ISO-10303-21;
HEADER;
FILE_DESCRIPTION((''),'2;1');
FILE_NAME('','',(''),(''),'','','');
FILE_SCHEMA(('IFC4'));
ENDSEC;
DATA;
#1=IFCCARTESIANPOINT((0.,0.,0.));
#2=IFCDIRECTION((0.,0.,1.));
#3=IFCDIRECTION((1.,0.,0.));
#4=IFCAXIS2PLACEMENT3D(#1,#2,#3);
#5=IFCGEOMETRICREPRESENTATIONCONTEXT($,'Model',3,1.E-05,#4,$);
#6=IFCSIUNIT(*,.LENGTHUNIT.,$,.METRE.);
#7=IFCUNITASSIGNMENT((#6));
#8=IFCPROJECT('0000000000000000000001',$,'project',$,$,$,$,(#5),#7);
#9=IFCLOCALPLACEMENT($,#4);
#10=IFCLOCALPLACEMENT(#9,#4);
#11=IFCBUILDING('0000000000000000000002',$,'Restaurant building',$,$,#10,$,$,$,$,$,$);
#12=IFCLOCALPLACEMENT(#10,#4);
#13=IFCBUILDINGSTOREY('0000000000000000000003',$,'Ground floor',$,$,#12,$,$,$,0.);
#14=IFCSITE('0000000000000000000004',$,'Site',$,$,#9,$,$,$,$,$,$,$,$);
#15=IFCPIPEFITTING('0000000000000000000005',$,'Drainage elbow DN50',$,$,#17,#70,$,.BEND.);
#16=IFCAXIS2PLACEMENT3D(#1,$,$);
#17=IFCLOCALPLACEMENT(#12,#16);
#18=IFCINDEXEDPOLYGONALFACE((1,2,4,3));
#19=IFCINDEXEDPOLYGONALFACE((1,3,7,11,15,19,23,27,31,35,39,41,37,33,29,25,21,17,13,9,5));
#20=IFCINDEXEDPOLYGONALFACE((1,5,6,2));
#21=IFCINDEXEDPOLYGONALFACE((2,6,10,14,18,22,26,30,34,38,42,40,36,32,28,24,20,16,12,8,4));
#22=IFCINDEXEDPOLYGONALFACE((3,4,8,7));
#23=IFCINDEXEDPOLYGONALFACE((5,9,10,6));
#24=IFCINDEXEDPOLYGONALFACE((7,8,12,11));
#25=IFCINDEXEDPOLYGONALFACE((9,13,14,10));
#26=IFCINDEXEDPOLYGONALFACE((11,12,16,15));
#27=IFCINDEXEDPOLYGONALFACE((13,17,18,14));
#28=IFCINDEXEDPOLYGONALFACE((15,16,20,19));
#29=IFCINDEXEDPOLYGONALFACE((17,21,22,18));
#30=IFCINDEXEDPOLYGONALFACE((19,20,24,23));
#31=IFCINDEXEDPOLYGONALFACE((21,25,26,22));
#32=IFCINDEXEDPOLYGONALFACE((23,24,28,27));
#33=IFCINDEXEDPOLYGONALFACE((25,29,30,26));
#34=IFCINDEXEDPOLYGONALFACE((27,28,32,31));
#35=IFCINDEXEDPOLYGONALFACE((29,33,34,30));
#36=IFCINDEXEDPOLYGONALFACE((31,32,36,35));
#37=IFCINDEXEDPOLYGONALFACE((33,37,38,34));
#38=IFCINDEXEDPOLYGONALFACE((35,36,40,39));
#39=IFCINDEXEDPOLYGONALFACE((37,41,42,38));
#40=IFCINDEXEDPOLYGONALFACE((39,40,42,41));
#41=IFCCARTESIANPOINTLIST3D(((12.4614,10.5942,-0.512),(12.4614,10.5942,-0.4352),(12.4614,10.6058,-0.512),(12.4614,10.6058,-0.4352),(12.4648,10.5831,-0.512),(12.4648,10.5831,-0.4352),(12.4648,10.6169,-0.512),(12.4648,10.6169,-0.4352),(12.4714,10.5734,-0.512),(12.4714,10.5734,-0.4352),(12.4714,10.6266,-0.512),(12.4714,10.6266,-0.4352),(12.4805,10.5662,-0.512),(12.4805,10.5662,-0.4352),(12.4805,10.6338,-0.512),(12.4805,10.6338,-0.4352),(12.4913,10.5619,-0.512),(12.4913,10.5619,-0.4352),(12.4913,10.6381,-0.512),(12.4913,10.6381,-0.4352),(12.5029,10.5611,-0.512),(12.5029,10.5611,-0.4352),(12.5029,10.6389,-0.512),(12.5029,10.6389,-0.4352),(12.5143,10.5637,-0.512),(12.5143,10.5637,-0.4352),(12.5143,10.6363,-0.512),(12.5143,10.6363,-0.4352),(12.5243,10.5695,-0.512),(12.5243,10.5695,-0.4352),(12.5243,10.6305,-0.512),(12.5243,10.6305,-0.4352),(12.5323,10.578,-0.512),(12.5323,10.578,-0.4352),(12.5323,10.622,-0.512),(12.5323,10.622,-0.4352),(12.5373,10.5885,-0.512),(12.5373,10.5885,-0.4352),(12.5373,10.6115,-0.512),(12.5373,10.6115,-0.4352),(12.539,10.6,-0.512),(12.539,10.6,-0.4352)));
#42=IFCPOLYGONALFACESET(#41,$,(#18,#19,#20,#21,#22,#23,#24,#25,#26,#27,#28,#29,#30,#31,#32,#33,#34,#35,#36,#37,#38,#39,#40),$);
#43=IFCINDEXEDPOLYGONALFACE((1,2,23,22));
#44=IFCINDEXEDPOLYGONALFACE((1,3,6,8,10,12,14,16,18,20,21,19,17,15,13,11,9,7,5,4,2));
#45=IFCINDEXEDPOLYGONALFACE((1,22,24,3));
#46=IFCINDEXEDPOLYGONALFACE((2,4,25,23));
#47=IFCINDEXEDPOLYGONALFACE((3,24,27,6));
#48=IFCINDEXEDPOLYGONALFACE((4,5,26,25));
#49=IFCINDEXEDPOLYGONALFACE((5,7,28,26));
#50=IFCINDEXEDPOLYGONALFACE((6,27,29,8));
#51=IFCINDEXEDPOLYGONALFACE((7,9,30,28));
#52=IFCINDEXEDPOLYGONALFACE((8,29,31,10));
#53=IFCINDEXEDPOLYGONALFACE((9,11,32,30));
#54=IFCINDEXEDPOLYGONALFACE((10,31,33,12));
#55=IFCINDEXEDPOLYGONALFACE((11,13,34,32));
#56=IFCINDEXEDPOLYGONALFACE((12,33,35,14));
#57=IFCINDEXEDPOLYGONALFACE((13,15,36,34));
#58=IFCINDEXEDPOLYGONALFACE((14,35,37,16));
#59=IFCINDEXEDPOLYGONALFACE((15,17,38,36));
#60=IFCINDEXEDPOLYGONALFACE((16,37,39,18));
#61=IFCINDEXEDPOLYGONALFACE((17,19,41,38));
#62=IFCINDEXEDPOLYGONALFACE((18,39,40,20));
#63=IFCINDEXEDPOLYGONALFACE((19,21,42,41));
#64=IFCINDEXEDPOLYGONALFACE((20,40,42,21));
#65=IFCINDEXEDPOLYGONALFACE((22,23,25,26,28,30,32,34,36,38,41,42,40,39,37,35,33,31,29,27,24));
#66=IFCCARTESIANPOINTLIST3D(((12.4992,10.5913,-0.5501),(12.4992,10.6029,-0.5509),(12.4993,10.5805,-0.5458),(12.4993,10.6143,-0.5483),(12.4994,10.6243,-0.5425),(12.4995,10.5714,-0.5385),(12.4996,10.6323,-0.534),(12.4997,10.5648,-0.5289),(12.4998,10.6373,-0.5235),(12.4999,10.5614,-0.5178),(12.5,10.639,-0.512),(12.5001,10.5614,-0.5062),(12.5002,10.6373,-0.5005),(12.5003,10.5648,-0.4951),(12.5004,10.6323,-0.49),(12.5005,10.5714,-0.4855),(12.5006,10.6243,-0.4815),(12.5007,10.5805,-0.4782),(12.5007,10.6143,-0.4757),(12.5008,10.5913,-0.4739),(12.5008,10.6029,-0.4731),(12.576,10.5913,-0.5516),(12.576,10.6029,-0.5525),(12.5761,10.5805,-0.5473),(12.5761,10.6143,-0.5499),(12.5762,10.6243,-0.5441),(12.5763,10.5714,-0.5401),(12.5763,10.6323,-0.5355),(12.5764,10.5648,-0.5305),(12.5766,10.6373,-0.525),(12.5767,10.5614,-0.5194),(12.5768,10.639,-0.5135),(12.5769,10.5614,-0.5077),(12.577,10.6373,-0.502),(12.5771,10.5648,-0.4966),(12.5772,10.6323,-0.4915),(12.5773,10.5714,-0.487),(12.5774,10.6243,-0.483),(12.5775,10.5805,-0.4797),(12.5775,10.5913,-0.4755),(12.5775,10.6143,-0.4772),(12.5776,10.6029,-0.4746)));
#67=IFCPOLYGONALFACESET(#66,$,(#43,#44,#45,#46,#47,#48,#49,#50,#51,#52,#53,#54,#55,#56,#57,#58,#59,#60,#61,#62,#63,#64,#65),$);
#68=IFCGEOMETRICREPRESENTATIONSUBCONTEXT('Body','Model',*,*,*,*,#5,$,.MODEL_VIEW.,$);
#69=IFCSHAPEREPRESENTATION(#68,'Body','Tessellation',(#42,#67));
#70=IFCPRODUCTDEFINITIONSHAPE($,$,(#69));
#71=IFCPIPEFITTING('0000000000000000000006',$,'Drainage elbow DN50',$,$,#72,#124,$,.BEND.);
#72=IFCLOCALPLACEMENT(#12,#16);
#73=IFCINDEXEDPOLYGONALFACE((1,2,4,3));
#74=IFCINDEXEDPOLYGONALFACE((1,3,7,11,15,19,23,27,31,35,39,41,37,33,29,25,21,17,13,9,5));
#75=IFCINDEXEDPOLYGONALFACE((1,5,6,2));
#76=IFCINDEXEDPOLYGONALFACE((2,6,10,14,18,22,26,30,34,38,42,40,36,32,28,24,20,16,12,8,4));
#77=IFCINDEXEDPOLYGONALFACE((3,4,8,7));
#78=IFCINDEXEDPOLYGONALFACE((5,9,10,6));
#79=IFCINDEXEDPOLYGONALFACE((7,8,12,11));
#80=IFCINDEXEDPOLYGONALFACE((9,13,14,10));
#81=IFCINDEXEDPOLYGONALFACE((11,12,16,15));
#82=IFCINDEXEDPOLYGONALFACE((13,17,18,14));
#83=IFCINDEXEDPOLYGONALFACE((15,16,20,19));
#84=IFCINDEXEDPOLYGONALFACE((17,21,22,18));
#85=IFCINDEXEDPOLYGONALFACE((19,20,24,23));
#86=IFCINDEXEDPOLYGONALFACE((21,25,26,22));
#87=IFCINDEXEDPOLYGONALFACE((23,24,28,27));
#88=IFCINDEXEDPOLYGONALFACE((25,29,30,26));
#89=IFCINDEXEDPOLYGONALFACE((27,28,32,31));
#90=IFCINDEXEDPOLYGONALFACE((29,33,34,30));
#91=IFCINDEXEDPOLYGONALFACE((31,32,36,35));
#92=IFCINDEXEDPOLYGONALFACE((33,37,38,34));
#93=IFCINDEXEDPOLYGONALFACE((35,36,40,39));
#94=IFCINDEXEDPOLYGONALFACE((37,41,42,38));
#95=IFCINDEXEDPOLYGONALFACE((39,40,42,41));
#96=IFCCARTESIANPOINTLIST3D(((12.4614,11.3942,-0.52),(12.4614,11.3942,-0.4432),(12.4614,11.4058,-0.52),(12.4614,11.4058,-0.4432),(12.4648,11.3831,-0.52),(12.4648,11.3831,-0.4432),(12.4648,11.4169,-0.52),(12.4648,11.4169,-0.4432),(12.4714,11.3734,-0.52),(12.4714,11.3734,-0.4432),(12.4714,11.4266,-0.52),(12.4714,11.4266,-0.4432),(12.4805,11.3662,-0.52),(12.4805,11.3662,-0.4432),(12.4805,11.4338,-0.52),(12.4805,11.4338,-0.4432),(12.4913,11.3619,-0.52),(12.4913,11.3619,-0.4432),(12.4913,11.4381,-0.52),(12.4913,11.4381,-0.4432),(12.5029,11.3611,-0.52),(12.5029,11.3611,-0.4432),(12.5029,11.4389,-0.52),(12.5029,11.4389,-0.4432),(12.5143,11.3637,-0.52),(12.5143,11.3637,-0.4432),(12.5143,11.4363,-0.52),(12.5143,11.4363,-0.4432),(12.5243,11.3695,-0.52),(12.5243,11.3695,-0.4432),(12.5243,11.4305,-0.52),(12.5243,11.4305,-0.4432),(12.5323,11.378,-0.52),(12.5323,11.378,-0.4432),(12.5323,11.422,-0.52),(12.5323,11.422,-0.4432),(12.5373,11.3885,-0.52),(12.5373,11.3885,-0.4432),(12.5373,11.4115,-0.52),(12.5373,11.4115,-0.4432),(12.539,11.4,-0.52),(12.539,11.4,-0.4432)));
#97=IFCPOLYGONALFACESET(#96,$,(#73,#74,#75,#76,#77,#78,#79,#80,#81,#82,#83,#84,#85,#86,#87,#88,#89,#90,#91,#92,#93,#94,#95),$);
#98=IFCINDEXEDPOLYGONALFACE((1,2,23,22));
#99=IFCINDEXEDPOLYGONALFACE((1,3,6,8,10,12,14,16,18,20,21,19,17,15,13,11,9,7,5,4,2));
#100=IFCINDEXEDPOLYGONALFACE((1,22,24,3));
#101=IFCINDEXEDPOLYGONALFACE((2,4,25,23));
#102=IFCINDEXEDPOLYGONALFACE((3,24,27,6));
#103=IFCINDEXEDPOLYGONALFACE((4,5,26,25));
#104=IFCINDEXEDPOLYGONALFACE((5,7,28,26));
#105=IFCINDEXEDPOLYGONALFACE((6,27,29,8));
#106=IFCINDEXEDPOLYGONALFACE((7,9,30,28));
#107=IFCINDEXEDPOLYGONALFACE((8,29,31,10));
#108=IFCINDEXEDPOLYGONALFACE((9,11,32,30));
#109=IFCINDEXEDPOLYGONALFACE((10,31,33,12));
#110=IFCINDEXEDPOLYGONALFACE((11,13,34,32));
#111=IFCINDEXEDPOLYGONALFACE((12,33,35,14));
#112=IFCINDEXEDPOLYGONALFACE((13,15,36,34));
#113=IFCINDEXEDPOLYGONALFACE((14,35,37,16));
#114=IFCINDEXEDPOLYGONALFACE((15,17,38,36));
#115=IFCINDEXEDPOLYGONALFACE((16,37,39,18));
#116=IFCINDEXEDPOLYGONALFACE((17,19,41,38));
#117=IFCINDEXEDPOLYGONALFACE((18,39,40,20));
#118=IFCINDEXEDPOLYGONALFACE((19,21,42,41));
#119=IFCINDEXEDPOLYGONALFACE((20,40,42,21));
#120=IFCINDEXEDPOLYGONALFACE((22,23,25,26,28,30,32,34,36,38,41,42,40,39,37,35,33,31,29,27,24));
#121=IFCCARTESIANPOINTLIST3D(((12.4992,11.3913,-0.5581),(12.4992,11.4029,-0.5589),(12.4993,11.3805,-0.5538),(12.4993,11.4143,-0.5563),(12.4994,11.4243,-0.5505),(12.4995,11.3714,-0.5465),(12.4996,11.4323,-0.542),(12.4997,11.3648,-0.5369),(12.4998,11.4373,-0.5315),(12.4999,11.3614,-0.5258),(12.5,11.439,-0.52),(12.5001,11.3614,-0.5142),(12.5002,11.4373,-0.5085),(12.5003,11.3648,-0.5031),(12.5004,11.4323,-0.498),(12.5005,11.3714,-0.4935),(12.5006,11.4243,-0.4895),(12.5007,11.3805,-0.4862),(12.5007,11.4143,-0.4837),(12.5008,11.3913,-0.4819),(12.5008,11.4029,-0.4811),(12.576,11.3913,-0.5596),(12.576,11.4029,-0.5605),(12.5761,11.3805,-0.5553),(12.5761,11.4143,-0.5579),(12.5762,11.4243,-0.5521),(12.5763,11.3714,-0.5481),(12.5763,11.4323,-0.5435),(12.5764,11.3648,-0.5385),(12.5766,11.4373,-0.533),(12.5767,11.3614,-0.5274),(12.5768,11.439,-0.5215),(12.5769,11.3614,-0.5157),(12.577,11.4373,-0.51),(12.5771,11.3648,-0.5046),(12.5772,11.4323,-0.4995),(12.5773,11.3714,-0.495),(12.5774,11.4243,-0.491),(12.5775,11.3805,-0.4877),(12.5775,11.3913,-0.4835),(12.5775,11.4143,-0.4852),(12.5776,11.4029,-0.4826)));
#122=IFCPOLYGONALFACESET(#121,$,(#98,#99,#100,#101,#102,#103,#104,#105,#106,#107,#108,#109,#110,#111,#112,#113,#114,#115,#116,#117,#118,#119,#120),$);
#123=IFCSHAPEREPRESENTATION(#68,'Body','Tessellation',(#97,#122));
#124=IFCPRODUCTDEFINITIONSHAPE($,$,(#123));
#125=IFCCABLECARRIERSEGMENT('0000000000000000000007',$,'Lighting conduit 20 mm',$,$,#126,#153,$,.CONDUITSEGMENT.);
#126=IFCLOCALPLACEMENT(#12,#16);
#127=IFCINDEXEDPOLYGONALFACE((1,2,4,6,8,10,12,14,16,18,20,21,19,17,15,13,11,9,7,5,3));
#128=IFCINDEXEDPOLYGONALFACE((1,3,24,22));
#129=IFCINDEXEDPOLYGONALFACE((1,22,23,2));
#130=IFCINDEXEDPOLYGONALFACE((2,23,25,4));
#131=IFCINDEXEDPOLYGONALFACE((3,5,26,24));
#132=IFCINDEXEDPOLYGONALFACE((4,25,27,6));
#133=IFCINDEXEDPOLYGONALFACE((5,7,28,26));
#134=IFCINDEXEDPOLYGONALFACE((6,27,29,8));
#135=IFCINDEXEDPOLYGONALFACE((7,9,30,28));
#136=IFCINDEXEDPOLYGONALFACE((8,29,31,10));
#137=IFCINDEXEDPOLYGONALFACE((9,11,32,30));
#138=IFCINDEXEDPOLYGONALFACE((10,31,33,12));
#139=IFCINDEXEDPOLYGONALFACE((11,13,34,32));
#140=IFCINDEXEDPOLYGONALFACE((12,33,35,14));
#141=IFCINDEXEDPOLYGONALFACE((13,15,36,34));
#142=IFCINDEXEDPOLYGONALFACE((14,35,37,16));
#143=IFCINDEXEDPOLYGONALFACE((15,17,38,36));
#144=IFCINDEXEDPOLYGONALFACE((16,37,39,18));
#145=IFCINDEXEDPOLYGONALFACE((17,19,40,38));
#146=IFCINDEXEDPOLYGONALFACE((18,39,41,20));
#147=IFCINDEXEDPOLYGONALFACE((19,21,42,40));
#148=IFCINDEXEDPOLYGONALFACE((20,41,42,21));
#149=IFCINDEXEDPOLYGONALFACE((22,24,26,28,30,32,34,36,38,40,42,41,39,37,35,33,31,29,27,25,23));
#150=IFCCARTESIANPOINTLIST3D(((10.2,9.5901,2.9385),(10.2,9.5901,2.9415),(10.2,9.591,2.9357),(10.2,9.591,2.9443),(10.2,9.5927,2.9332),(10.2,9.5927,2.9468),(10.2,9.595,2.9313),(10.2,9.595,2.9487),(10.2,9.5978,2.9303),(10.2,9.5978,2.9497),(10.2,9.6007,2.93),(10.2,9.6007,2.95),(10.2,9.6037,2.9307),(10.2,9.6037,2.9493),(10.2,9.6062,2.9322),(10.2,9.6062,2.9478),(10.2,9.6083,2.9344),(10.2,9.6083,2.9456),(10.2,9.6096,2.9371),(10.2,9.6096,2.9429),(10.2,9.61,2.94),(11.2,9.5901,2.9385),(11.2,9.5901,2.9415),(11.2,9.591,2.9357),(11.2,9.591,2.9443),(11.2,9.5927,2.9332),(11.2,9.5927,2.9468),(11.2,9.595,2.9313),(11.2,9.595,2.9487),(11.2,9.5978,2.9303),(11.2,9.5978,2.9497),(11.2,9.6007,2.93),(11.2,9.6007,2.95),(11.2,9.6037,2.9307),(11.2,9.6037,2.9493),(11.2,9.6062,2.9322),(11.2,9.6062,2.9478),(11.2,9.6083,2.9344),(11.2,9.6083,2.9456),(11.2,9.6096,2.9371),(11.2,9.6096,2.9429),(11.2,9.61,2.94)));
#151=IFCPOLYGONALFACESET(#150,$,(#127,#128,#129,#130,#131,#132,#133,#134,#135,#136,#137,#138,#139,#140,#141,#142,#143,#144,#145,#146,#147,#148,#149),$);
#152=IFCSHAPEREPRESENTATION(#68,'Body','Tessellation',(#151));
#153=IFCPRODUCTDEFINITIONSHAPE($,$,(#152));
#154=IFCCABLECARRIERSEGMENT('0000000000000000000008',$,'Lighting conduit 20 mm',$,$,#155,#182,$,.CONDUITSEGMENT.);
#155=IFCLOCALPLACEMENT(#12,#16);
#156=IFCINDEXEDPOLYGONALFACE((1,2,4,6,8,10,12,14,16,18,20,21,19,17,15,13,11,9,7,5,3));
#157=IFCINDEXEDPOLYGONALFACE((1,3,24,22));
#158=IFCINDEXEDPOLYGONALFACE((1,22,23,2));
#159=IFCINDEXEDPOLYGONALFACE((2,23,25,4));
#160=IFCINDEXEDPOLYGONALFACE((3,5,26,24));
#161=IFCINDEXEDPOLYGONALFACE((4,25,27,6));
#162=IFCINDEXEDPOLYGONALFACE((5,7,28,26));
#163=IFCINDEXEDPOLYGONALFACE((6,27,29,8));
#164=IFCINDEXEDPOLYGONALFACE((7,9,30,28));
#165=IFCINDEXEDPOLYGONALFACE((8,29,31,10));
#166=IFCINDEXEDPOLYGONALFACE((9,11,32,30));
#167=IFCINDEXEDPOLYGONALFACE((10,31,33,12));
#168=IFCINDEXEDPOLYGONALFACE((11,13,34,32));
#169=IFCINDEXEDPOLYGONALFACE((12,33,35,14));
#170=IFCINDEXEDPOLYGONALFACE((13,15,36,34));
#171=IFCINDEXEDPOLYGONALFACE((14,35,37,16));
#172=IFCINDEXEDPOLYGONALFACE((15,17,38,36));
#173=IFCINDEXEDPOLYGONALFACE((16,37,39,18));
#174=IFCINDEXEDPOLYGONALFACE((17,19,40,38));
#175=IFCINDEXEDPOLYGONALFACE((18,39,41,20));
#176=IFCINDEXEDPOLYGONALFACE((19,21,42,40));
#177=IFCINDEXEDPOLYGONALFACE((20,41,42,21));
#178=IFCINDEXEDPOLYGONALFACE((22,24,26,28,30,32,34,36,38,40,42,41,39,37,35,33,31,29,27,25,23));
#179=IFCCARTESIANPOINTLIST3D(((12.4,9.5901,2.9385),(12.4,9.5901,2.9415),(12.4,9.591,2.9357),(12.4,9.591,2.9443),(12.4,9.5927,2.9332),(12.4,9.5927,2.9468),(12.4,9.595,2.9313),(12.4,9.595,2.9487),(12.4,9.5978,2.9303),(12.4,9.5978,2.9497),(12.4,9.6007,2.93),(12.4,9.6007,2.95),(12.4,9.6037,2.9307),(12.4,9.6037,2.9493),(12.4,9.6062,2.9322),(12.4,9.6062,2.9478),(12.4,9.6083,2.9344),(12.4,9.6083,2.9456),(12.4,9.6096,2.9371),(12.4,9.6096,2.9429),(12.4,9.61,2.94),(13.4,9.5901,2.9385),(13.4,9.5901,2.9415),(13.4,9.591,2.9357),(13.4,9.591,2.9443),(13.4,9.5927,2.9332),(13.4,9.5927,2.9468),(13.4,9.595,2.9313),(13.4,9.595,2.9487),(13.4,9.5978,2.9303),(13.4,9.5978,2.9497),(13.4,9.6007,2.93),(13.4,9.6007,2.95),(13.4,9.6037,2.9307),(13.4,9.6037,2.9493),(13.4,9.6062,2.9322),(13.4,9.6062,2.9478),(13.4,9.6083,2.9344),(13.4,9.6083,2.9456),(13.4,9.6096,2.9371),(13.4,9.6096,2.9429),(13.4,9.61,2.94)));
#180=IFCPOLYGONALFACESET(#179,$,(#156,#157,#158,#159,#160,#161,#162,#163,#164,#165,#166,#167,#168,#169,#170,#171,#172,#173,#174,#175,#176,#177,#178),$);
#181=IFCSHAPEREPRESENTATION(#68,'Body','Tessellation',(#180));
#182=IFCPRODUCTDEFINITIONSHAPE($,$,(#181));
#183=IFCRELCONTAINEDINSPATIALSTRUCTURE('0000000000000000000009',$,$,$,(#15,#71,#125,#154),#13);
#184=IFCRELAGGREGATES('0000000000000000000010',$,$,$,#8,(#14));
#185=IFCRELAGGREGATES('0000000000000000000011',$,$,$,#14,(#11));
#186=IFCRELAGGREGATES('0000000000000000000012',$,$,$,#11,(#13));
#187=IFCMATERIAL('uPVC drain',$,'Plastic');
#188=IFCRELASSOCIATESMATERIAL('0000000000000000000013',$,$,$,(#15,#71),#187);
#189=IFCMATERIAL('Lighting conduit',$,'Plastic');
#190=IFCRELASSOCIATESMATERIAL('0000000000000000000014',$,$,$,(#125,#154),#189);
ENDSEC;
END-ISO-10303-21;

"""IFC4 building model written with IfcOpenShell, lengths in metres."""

from ifc_helpers import new_model, si_unit, frame, origin, origin_with_axes, origin_2d, place, context, subcontext, project, spatial, circle, extrude, material, element, save


model = new_model("IFC4")

# Units and contexts
model_context = context("Model", 3, precision=1e-05, world=origin_with_axes())
body_context = subcontext(model_context, "Body", "Model", "MODEL_VIEW")
ifc_project = project(units=[si_unit("LENGTHUNIT", "METRE")], contexts=[model_context])

# Site, building, storey
site_placement = place(None, origin_with_axes())
site = spatial("IfcSite", under=ifc_project, at=site_placement, Name="Site")
building_placement = place(site_placement, origin_with_axes())
building = spatial("IfcBuilding", under=site, at=building_placement, Name="Restaurant building")
storey_placement = place(building_placement, origin_with_axes())
storey = spatial("IfcBuildingStorey", under=building, at=storey_placement, Name="Ground floor", Elevation=0.0)

# Shared definitions
ifc_material_1 = material(Name="uPVC drain", Category="Plastic")

# Pipe fittings
for number, where, name in (
    (1, (12.5, 10.6, -0.512), "Drainage elbow DN50"),
    (2, (12.5, 11.4, -0.52), "Drainage elbow DN50"),
):
    element("IfcPipeFitting", number, at=place(storey_placement, frame(where)), inside=storey, material=ifc_material_1, Name=name, PredefinedType="BEND", context=body_context, shape_type="SweptSolid", body=[
        extrude(circle(Radius=0.039, at=origin_2d()), origin(), (0.0, 0.0, 1.0), 0.0768),
        extrude(circle(Radius=0.039, at=origin_2d()), frame((0.0, 0.0, 0.0), z_axis=(0.9998, 0.0, -0.019996), x_axis=(0.0, 1.0, 0.0)), (0.0, 0.0, 1.0), 0.0768),
    ])

# Cable carrier segments
ifc_material_2 = material(Name="Lighting conduit", Category="Plastic")
for number, where, name in (
    (3, (10.2, 9.6, 2.94), "Lighting conduit 20 mm"),
    (4, (12.4, 9.6, 2.94), "Lighting conduit 20 mm"),
):
    element("IfcCableCarrierSegment", number, at=place(storey_placement, frame(where)), inside=storey, material=ifc_material_2, Name=name, PredefinedType="CONDUITSEGMENT", context=body_context, shape_type="SweptSolid", body=[
        extrude(circle(Radius=0.01, at=origin_2d()), frame((0.0, 0.0, 0.0), z_axis=(1.0, 0.0, 0.0), x_axis=(0.0, 1.0, 0.0)), (0.0, 0.0, 1.0), 1.0),
    ])

save(model, "model.ifc")
